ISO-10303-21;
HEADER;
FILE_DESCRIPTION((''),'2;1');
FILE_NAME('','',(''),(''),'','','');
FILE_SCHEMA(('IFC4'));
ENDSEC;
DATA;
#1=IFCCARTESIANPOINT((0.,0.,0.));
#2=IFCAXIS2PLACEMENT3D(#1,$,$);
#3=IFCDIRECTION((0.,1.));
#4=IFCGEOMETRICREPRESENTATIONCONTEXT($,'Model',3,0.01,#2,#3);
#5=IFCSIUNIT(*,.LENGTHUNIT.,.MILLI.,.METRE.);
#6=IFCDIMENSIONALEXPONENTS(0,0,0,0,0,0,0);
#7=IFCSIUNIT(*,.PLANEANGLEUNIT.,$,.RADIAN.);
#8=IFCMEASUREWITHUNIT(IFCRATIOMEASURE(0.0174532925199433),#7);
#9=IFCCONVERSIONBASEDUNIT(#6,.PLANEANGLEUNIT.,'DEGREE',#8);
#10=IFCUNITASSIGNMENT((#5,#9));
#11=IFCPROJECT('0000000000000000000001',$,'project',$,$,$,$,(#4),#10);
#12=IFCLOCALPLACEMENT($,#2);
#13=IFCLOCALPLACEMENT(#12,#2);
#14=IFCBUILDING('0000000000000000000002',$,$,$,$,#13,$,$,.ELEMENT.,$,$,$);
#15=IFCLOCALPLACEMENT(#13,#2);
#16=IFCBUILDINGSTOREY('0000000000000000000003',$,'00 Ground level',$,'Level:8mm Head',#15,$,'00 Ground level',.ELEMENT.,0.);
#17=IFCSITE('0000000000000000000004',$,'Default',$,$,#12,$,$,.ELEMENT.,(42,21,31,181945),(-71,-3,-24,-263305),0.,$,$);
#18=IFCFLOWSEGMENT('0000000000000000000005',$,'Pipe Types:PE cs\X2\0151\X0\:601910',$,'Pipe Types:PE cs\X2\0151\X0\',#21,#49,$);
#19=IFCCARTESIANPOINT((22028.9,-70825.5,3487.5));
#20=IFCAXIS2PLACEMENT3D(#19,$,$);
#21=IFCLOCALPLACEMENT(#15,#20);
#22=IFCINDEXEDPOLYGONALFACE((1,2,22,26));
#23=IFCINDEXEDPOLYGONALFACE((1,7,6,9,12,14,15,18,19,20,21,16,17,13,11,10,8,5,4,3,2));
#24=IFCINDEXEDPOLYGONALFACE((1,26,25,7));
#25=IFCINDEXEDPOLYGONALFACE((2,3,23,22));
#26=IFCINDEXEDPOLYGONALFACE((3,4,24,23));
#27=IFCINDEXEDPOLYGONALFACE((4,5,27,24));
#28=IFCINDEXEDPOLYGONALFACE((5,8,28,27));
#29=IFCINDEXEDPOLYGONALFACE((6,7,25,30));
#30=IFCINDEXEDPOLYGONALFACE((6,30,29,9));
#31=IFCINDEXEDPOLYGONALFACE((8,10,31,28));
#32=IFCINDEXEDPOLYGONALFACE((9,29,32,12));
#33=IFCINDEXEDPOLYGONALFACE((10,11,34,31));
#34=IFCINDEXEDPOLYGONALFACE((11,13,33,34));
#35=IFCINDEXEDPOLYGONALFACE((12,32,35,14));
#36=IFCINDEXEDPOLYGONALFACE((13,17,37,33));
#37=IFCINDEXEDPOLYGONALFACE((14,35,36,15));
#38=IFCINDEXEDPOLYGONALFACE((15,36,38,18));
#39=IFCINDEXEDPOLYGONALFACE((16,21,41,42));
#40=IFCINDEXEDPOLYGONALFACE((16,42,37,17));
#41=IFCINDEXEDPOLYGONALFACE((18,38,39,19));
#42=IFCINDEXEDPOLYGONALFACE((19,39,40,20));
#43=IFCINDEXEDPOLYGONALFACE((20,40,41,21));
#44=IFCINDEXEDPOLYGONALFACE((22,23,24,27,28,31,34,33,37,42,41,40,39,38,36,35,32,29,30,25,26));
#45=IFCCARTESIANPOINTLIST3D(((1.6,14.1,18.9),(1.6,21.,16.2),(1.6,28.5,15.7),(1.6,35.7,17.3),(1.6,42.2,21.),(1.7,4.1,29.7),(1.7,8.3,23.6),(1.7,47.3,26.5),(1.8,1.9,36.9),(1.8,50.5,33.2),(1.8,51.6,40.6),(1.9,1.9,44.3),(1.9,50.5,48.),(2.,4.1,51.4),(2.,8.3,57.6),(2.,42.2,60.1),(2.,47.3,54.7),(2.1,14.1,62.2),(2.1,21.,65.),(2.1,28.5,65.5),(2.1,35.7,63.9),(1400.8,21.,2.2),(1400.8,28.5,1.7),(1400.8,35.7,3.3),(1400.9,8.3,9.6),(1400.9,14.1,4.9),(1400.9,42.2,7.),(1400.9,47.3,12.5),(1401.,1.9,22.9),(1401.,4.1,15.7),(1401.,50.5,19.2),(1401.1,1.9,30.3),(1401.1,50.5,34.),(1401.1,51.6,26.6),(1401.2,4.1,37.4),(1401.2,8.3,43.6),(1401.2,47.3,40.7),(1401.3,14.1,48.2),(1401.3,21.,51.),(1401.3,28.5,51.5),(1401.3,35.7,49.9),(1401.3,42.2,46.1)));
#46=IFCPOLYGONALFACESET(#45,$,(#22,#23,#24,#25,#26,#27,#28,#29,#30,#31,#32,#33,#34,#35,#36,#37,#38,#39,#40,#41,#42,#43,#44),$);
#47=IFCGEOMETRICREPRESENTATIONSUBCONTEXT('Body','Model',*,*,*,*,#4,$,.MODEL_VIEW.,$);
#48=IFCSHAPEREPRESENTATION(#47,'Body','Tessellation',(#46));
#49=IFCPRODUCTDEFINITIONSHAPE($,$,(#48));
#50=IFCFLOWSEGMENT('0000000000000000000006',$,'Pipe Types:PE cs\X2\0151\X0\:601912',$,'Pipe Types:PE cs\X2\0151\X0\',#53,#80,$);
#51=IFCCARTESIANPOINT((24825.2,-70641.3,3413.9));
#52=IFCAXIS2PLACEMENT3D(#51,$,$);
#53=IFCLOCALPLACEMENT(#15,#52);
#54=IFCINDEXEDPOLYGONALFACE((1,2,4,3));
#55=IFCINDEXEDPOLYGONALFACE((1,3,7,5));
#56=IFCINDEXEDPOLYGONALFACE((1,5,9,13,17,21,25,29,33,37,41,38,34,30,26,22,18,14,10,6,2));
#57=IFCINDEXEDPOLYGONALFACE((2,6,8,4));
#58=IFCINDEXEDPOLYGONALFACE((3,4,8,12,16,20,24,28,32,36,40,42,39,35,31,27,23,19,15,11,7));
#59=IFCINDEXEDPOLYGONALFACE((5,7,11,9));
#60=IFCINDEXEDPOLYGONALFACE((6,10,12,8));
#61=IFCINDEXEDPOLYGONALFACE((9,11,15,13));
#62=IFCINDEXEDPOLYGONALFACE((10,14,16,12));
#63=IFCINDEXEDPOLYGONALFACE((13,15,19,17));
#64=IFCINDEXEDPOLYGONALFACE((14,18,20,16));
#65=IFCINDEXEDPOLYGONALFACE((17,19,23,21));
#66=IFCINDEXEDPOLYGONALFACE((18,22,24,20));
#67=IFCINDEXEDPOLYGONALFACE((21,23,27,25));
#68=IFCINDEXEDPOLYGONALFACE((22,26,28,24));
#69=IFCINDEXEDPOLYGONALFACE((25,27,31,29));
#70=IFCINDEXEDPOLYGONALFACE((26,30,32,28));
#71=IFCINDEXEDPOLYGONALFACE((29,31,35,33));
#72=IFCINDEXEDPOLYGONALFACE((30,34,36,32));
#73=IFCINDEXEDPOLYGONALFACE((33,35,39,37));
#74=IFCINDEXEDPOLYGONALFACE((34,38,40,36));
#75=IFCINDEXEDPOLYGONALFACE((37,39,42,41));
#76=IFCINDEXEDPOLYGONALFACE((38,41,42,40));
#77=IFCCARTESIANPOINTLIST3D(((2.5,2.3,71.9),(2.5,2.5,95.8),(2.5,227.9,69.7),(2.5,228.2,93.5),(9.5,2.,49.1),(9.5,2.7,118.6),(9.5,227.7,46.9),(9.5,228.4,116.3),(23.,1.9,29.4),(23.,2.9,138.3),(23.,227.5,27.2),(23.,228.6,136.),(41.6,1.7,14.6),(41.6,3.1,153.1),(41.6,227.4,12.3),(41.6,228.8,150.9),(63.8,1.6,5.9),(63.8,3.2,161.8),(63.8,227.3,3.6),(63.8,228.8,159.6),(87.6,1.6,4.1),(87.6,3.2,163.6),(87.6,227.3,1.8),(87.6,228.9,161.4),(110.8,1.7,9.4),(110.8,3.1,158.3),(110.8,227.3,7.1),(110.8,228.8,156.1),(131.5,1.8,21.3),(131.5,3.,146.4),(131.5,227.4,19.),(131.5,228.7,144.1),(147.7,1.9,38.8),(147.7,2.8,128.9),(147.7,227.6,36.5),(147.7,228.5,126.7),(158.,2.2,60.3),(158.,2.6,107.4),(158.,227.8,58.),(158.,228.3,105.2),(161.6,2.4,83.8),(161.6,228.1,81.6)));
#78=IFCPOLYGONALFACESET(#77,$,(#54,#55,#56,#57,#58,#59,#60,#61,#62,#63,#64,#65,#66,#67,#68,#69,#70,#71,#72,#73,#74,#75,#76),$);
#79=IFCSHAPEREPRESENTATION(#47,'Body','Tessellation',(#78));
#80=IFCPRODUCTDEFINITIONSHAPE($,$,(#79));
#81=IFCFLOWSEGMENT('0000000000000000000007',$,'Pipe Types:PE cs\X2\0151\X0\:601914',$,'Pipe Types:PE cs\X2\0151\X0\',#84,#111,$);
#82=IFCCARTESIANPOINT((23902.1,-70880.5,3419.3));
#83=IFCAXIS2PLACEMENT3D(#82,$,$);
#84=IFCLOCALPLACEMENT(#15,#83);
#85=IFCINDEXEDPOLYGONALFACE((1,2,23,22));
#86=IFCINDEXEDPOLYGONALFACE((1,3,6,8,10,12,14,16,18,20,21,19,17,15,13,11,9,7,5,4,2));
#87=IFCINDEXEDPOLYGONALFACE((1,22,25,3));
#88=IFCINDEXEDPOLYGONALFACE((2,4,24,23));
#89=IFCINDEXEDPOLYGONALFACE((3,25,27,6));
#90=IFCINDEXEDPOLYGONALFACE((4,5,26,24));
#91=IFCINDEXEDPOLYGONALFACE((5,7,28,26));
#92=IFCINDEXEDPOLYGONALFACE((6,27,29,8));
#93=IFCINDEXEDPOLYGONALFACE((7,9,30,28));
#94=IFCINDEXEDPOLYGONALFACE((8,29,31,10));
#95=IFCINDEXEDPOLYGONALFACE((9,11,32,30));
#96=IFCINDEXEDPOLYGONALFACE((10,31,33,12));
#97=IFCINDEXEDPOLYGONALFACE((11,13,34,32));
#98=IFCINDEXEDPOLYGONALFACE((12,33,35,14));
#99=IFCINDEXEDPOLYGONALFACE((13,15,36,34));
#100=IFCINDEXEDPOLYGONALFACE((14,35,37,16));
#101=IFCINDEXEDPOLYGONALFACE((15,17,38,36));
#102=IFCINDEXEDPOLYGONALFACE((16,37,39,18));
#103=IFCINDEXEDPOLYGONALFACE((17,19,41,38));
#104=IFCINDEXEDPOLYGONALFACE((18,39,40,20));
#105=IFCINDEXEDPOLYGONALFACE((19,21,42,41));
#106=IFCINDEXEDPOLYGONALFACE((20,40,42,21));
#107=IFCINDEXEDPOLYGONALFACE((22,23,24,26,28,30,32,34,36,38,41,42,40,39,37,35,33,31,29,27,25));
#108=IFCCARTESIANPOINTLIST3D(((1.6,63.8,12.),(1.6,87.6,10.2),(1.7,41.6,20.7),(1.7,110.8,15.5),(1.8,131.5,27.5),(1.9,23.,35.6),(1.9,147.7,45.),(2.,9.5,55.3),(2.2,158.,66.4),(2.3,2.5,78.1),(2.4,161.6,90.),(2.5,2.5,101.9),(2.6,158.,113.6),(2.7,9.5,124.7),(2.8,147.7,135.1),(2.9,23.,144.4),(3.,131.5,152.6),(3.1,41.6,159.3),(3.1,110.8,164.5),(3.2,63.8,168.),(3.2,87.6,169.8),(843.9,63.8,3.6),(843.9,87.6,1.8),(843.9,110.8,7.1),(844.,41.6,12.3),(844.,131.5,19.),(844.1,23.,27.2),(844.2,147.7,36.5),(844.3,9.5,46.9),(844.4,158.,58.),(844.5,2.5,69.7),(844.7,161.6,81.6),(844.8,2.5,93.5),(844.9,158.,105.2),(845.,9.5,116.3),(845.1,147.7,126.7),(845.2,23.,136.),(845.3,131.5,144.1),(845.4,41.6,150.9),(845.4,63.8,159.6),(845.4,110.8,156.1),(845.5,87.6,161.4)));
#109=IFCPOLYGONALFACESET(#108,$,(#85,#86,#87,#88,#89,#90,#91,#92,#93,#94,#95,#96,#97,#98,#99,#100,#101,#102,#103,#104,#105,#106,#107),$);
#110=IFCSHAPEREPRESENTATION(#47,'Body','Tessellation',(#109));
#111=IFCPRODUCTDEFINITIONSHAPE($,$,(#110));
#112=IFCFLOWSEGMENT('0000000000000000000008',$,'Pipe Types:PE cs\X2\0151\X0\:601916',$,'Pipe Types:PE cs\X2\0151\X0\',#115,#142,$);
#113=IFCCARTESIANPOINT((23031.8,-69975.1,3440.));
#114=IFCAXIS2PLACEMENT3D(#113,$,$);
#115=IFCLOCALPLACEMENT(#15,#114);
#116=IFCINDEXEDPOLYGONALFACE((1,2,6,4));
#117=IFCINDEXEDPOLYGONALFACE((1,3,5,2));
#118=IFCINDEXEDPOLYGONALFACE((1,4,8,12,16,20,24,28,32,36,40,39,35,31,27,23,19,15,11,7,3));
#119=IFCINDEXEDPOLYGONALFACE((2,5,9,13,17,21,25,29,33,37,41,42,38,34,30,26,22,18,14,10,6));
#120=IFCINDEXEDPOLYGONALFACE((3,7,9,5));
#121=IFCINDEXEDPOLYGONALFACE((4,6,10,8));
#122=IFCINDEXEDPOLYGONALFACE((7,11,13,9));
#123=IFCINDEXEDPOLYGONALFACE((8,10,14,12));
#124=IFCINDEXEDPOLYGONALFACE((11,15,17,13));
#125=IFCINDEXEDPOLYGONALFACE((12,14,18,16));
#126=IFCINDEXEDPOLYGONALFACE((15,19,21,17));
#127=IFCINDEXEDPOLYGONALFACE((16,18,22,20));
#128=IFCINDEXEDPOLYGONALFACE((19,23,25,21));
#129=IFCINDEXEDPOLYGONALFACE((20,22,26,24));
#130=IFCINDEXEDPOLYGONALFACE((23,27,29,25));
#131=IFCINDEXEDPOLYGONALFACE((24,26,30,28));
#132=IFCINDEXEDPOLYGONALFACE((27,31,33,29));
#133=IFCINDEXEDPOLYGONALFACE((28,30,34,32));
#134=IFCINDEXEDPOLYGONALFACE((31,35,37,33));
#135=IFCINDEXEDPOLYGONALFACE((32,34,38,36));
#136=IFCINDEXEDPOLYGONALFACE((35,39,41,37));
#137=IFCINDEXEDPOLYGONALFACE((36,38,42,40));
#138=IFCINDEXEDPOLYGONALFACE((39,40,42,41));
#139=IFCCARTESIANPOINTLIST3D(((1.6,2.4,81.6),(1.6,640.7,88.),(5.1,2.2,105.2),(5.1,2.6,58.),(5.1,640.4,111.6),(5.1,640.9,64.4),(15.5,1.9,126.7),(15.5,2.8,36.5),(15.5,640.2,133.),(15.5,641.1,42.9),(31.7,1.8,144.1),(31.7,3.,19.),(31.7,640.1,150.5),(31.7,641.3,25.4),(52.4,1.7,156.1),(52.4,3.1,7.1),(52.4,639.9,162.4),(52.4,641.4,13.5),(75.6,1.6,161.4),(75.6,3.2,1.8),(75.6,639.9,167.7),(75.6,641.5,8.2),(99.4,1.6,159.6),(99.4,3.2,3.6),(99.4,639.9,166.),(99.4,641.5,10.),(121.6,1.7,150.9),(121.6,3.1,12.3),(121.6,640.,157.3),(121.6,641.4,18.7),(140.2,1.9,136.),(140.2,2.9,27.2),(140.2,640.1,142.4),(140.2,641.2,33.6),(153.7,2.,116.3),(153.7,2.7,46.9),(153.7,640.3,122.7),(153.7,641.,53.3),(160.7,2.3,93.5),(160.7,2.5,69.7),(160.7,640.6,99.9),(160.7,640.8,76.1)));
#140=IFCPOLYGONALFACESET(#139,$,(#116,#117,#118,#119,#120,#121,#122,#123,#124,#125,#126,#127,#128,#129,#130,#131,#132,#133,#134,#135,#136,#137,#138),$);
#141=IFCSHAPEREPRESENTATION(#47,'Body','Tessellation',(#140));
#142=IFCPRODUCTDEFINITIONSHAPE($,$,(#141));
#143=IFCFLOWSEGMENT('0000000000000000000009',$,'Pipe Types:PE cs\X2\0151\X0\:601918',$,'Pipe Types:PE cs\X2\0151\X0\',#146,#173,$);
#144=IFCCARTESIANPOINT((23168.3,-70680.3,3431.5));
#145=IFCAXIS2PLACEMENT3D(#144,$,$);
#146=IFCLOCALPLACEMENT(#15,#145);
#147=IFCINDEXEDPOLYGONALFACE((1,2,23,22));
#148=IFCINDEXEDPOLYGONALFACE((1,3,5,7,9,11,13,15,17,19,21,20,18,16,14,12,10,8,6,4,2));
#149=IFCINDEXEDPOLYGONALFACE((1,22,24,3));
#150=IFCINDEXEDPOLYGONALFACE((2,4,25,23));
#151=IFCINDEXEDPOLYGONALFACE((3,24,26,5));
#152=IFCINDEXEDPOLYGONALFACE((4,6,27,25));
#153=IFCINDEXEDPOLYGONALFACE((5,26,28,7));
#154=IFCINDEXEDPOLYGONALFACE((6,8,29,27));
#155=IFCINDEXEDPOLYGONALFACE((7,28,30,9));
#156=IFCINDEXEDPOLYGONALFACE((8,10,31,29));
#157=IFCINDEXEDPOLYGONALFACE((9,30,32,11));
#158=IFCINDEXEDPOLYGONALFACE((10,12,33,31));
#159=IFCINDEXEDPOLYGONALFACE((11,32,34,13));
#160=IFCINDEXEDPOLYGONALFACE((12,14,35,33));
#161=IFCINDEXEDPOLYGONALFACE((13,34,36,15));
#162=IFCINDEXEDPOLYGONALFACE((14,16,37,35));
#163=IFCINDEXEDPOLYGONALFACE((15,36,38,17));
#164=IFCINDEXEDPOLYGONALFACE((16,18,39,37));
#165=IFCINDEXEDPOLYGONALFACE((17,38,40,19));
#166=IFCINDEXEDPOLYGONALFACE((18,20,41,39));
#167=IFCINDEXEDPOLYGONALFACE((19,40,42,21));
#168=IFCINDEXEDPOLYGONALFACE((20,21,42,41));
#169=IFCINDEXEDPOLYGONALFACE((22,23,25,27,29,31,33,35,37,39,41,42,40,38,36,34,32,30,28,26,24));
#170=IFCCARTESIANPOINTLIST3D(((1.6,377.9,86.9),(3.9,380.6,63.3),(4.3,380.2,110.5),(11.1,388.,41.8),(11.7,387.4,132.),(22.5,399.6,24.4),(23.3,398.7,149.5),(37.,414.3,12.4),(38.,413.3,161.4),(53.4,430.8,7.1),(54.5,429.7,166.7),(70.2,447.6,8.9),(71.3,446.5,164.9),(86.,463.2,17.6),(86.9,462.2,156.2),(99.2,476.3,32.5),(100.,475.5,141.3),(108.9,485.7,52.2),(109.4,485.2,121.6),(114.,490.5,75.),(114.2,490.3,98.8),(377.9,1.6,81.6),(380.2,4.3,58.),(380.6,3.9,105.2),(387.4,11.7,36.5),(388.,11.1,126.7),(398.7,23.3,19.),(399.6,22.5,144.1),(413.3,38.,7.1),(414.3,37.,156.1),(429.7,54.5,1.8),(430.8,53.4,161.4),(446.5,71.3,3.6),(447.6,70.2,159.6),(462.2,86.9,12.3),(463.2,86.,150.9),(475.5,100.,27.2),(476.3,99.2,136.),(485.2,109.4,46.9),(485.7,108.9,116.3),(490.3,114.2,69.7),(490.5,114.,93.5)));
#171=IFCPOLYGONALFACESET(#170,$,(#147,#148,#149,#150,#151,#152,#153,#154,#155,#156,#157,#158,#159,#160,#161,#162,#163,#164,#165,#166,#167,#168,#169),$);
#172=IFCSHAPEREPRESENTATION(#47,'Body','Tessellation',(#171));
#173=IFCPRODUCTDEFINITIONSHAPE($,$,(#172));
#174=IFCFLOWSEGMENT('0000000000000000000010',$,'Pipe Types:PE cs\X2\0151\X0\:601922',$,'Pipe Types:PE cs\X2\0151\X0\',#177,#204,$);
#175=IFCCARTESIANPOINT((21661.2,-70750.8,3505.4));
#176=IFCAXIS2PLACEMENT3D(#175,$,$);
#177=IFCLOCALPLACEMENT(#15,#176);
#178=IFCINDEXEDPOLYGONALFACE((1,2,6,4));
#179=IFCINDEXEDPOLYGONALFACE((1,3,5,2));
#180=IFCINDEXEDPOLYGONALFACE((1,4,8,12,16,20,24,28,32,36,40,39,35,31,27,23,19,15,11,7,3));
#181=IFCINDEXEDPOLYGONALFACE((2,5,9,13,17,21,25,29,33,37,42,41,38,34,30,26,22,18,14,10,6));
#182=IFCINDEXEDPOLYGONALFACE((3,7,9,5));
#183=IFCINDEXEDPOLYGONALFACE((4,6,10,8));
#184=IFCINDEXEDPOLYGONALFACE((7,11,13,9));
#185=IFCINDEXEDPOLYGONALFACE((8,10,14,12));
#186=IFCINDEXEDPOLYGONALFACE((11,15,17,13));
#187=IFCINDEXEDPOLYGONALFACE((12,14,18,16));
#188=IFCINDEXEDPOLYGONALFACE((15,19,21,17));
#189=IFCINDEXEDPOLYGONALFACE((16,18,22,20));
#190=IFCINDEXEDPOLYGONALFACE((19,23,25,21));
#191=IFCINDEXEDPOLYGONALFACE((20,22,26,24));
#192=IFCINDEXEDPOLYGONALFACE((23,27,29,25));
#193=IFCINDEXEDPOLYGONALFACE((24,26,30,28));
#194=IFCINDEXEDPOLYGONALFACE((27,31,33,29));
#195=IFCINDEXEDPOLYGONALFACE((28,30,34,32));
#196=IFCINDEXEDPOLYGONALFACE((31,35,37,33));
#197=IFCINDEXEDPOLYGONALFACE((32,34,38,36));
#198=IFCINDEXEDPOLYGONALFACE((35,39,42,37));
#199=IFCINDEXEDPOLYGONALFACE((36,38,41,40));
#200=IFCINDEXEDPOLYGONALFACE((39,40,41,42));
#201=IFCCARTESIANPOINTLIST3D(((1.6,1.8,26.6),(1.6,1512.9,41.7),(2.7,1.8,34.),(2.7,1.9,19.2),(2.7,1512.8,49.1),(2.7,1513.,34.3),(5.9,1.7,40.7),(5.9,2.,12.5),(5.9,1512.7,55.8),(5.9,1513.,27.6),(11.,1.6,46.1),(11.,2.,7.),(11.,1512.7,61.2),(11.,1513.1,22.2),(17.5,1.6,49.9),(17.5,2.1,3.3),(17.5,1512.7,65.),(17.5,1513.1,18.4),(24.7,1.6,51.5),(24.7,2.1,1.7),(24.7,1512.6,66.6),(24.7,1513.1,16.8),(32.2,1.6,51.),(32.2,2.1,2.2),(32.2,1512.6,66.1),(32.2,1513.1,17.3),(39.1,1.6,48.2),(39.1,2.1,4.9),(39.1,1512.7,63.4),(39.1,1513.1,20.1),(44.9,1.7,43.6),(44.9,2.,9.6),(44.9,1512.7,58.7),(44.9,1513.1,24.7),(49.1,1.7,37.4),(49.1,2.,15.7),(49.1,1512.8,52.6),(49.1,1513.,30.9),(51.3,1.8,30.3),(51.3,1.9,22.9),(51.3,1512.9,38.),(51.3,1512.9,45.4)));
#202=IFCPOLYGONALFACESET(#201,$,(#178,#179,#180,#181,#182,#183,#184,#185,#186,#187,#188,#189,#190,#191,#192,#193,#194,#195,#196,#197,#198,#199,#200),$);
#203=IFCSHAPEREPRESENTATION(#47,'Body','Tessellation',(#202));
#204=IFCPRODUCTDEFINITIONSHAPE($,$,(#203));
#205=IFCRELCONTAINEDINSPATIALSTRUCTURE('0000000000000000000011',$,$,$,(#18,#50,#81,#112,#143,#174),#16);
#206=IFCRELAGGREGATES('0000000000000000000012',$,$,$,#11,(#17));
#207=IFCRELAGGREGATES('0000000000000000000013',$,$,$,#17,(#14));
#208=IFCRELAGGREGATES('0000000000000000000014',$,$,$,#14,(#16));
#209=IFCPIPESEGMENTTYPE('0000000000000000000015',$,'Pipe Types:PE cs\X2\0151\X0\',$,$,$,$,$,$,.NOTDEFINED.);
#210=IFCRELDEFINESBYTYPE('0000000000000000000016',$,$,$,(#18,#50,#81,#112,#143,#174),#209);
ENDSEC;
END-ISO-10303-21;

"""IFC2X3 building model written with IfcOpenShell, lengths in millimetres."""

from ifc_helpers import new_model, entity, si_unit, converted_unit, direction, frame, frame_2d, origin, origin_2d_with_axis, place, context, subcontext, project, spatial, circle, extrude, type_object, element, save


model = new_model("IFC2X3")

# Units and contexts
model_context = context("Model", 3, precision=0.01, world=origin(), true_north=direction((0.0, 1.0)))
body_context = subcontext(model_context, "Body", "Model", "MODEL_VIEW")
ifc_project = project(units=[si_unit("LENGTHUNIT", "METRE", prefix="MILLI"), converted_unit("PLANEANGLEUNIT", "DEGREE", entity("IfcRatioMeasure", 0.0174532925199433), si_unit("PLANEANGLEUNIT", "RADIAN"), dimensions=[0, 0, 0, 0, 0, 0, 0])], contexts=[model_context])

# Site, building, storey
site_placement = place(None, origin())
site = spatial("IfcSite", under=ifc_project, at=site_placement, Name="Default", CompositionType="ELEMENT", RefLatitude=(42, 21, 31, 181945), RefLongitude=(-71, -3, -24, -263305), RefElevation=0.0)
building_placement = place(site_placement, origin())
building = spatial("IfcBuilding", under=site, at=building_placement, CompositionType="ELEMENT")
storey_placement = place(building_placement, origin())
storey = spatial("IfcBuildingStorey", under=building, at=storey_placement, Name="00 Ground level", ObjectType="Level:8mm Head", LongName="00 Ground level", CompositionType="ELEMENT", Elevation=0.0)

# Flow segments
pipe_segment_type = type_object("IfcPipeSegmentType", Name="Pipe Types:PE cső", PredefinedType="NOTDEFINED")
flow_segment_1_placement = place(storey_placement, frame((22028.9, -70825.5, 3487.5)))
element("IfcFlowSegment", 1, at=flow_segment_1_placement, inside=storey, type_object=pipe_segment_type, Name="Pipe Types:PE cső:601910", ObjectType="Pipe Types:PE cső", context=body_context, shape_type="SweptSolid", body=[
    extrude(circle(Radius=25.0, at=origin_2d_with_axis()), frame((1.8, 26.6, 40.6), z_axis=(0.99995, 0.0, -0.01), x_axis=(0.0, 1.0, 0.0)), (0.0, 0.0, 1.0), 1399.3),
])
flow_segment_2_placement = place(storey_placement, frame((24825.2, -70641.3, 3413.9)))
element("IfcFlowSegment", 2, at=flow_segment_2_placement, inside=storey, type_object=pipe_segment_type, Name="Pipe Types:PE cső:601912", ObjectType="Pipe Types:PE cső", context=body_context, shape_type="SweptSolid", body=[
    extrude(circle(Radius=80.0, at=frame_2d((0.0, 0.0), x_axis=(1.0, 0.0))), frame((81.6, 2.4, 83.8), z_axis=(0.0, 0.99995, -0.01), x_axis=(1.0, 0.0, 0.0)), (0.0, 0.0, 1.0), 225.7),
])
flow_segment_3_placement = place(storey_placement, frame((23902.1, -70880.5, 3419.3)))
element("IfcFlowSegment", 3, at=flow_segment_3_placement, inside=storey, type_object=pipe_segment_type, Name="Pipe Types:PE cső:601914", ObjectType="Pipe Types:PE cső", context=body_context, shape_type="SweptSolid", body=[
    extrude(circle(Radius=80.0, at=origin_2d_with_axis()), frame((2.4, 81.6, 90.0), z_axis=(0.99995, 0.0, -0.01), x_axis=(0.0, 1.0, 0.0)), (0.0, 0.0, 1.0), 842.3),
])
flow_segment_4_placement = place(storey_placement, frame((23031.8, -69975.1, 3440.0)))
element("IfcFlowSegment", 4, at=flow_segment_4_placement, inside=storey, type_object=pipe_segment_type, Name="Pipe Types:PE cső:601916", ObjectType="Pipe Types:PE cső", context=body_context, shape_type="SweptSolid", body=[
    extrude(circle(Radius=80.0, at=origin_2d_with_axis()), frame((81.6, 2.4, 81.6), z_axis=(0.0, 0.99995, 0.01), x_axis=(-1.0, 0.0, 0.0)), (0.0, 0.0, 1.0), 638.3),
])
flow_segment_5_placement = place(storey_placement, frame((23168.3, -70680.3, 3431.5)))
element("IfcFlowSegment", 5, at=flow_segment_5_placement, inside=storey, type_object=pipe_segment_type, Name="Pipe Types:PE cső:601918", ObjectType="Pipe Types:PE cső", context=body_context, shape_type="SweptSolid", body=[
    extrude(circle(Radius=80.0, at=frame_2d((0.0, 0.0), x_axis=(1.0, 0.0))), frame((58.2, 434.4, 86.9), z_axis=(0.707071, -0.707071, -0.01), x_axis=(-0.707107, -0.707107, 0.0)), (0.0, 0.0, 1.0), 532.2),
])
flow_segment_6_placement = place(storey_placement, frame((21661.2, -70750.8, 3505.4)))
element("IfcFlowSegment", 6, at=flow_segment_6_placement, inside=storey, type_object=pipe_segment_type, Name="Pipe Types:PE cső:601922", ObjectType="Pipe Types:PE cső", context=body_context, shape_type="SweptSolid", body=[
    extrude(circle(Radius=25.0, at=frame_2d((0.0, 0.0), x_axis=(1.0, 0.0))), frame((26.6, 1.8, 26.6), z_axis=(0.0, 0.99995, 0.01), x_axis=(-1.0, 0.0, 0.0)), (0.0, 0.0, 1.0), 1511.1),
])

save(model, "model.ifc")
